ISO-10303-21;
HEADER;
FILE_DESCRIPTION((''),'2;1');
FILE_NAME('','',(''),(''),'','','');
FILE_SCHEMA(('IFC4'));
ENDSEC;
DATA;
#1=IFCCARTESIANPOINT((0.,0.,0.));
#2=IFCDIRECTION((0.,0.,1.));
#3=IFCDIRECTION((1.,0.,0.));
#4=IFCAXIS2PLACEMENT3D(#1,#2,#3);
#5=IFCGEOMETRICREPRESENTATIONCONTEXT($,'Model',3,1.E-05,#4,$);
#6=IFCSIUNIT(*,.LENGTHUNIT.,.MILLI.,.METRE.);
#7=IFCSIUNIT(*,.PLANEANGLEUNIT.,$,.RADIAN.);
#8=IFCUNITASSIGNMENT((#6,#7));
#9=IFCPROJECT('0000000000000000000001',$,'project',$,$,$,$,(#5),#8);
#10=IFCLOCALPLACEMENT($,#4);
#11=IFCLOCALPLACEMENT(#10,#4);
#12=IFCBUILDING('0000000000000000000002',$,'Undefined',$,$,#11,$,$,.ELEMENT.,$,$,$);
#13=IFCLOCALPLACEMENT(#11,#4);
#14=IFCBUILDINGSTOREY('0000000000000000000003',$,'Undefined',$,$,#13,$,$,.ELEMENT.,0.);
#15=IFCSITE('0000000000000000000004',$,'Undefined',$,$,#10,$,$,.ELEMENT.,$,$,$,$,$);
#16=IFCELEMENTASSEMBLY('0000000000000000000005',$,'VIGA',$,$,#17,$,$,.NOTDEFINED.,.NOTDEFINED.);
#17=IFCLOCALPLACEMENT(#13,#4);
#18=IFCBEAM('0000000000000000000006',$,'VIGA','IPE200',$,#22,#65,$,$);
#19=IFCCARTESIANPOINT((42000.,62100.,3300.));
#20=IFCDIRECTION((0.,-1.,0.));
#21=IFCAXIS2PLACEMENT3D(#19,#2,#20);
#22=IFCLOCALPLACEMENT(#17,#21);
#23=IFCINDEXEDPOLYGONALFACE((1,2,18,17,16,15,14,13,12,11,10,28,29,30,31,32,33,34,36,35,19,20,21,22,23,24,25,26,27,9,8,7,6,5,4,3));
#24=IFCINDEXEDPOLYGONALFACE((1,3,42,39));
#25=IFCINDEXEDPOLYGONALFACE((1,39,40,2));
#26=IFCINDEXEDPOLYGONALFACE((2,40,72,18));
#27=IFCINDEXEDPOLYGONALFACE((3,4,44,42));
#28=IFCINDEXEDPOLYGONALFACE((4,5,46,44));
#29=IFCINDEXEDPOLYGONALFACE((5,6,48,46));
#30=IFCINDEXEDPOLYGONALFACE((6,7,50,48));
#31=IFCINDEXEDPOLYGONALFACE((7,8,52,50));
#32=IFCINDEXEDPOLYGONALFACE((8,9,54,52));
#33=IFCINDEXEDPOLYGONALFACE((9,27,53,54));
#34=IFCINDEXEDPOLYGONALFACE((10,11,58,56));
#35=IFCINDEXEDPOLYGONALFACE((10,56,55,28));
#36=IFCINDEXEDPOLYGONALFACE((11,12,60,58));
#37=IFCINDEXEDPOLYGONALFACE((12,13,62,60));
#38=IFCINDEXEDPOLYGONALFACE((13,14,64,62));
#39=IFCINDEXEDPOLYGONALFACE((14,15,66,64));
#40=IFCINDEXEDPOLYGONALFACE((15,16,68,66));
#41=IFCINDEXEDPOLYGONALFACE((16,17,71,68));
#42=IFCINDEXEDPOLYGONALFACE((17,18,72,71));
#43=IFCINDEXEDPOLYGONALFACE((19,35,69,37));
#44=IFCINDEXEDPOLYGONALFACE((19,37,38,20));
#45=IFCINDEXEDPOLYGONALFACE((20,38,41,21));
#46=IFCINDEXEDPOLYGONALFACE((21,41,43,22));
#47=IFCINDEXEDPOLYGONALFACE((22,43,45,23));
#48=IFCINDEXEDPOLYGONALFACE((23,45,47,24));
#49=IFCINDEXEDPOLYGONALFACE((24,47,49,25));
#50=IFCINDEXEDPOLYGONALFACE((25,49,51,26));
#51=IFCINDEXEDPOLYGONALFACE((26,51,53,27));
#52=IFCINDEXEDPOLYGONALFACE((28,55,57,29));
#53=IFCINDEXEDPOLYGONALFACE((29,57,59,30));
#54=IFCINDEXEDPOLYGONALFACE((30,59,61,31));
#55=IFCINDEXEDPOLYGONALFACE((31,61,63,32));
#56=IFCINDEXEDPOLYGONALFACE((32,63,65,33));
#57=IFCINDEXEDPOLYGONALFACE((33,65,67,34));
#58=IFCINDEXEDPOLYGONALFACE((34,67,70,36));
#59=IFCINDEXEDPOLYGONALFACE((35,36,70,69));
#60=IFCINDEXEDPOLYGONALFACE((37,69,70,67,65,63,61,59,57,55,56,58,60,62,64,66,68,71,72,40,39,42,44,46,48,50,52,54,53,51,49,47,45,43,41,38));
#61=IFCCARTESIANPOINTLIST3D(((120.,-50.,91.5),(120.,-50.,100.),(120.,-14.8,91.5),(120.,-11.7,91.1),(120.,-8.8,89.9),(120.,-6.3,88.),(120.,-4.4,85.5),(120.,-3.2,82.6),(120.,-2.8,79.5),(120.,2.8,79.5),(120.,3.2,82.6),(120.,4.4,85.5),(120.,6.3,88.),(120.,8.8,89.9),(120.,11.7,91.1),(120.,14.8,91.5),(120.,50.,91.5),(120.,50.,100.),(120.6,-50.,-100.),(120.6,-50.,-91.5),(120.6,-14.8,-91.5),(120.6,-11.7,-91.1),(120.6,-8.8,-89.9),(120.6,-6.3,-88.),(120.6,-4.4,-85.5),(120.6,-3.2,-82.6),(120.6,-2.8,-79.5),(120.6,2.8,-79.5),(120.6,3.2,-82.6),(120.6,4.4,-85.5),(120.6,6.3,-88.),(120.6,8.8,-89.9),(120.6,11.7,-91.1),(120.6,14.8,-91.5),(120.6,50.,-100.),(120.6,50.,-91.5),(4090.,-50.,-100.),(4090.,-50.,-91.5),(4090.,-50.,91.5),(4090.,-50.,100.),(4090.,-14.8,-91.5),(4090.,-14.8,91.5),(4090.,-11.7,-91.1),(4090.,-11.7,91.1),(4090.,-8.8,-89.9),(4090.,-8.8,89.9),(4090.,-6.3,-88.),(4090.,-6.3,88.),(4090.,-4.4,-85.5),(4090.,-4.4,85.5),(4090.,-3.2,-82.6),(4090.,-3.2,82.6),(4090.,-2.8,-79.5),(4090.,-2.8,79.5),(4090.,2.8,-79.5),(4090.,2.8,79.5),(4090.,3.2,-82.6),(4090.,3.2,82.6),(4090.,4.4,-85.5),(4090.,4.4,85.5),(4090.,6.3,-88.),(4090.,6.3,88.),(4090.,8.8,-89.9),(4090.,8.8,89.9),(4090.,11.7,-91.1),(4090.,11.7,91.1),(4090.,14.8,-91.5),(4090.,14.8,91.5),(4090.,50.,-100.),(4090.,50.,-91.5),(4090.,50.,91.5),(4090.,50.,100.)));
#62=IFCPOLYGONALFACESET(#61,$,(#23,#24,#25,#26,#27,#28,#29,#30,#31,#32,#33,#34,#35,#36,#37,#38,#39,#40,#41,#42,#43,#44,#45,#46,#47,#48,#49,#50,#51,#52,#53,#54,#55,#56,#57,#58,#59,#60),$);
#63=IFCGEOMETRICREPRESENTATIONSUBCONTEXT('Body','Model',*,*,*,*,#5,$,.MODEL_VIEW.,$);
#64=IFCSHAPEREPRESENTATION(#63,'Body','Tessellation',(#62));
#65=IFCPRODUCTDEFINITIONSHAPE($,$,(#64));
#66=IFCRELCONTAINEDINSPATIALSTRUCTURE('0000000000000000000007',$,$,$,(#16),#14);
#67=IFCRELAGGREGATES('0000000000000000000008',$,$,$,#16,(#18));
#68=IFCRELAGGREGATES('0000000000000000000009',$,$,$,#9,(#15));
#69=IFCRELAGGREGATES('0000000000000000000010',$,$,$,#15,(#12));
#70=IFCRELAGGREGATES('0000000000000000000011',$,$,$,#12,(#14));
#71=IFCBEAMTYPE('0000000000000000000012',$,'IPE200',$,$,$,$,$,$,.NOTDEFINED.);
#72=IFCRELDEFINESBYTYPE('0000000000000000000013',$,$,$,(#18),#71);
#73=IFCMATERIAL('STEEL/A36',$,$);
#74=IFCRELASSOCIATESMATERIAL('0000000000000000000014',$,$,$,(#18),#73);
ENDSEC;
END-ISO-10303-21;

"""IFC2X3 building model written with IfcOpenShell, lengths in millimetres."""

from ifc_helpers import new_model, si_unit, frame, origin_with_axes, origin_2d_with_axis, place, context, subcontext, project, spatial, i_section, extrude, clip, halfspace, material, type_object, element, aggregate, save


model = new_model("IFC2X3")

# Units and contexts
model_context = context("Model", 3, precision=1e-05, world=origin_with_axes())
body_context = subcontext(model_context, "Body", "Model", "MODEL_VIEW")
ifc_project = project(units=[si_unit("LENGTHUNIT", "METRE", prefix="MILLI"), si_unit("PLANEANGLEUNIT", "RADIAN")], contexts=[model_context])

# Site, building, storey
site_placement = place(None, origin_with_axes())
site = spatial("IfcSite", under=ifc_project, at=site_placement, Name="Undefined", CompositionType="ELEMENT")
building_placement = place(site_placement, origin_with_axes())
building = spatial("IfcBuilding", under=site, at=building_placement, Name="Undefined", CompositionType="ELEMENT")
storey_placement = place(building_placement, origin_with_axes())
storey = spatial("IfcBuildingStorey", under=building, at=storey_placement, Name="Undefined", CompositionType="ELEMENT", Elevation=0.0)

# Shared definitions
ifc_material_1 = material(Name="STEEL/A36")

# Element assembly, beam
assembly_1_placement = place(storey_placement, origin_with_axes())
assembly_1 = element("IfcElementAssembly", 1, at=assembly_1_placement, inside=storey, Name="VIGA", AssemblyPlace="NOTDEFINED", PredefinedType="NOTDEFINED")
beam_type_1 = type_object("IfcBeamType", Name="IPE200", PredefinedType="NOTDEFINED")
beam_1_placement = place(assembly_1_placement, frame((42000.0, 62100.0, 3300.0), z_axis=(0.0, 0.0, 1.0), x_axis=(0.0, -1.0, 0.0)))
beam_1 = element("IfcBeam", 2, at=beam_1_placement, type_object=beam_type_1, material=ifc_material_1, Name="VIGA", Description="IPE200", context=body_context, shape_type="Clipping", body=[
    clip(clip(extrude(i_section(OverallWidth=100.0, OverallDepth=200.0, WebThickness=5.6, FlangeThickness=8.5, FilletRadius=12.0, at=origin_2d_with_axis()), frame((4200.0, 0.0, 0.0), z_axis=(-1.0, 0.0, 0.0), x_axis=(0.0, -1.0, 0.0)), (0.0, 0.0, 1.0), 4200.0), halfspace(frame((4090.0, -400.0, 200.0), z_axis=(1.0, 0.0, 0.0), x_axis=(0.0, 1.0, 0.0)), False)), halfspace(frame((120.0, 0.0, 100.0), z_axis=(-0.999995, 0.0, -0.003301), x_axis=(0.0, -1.0, 0.0)), False)),
])

aggregate(assembly_1, [beam_1])

save(model, "model.ifc")
